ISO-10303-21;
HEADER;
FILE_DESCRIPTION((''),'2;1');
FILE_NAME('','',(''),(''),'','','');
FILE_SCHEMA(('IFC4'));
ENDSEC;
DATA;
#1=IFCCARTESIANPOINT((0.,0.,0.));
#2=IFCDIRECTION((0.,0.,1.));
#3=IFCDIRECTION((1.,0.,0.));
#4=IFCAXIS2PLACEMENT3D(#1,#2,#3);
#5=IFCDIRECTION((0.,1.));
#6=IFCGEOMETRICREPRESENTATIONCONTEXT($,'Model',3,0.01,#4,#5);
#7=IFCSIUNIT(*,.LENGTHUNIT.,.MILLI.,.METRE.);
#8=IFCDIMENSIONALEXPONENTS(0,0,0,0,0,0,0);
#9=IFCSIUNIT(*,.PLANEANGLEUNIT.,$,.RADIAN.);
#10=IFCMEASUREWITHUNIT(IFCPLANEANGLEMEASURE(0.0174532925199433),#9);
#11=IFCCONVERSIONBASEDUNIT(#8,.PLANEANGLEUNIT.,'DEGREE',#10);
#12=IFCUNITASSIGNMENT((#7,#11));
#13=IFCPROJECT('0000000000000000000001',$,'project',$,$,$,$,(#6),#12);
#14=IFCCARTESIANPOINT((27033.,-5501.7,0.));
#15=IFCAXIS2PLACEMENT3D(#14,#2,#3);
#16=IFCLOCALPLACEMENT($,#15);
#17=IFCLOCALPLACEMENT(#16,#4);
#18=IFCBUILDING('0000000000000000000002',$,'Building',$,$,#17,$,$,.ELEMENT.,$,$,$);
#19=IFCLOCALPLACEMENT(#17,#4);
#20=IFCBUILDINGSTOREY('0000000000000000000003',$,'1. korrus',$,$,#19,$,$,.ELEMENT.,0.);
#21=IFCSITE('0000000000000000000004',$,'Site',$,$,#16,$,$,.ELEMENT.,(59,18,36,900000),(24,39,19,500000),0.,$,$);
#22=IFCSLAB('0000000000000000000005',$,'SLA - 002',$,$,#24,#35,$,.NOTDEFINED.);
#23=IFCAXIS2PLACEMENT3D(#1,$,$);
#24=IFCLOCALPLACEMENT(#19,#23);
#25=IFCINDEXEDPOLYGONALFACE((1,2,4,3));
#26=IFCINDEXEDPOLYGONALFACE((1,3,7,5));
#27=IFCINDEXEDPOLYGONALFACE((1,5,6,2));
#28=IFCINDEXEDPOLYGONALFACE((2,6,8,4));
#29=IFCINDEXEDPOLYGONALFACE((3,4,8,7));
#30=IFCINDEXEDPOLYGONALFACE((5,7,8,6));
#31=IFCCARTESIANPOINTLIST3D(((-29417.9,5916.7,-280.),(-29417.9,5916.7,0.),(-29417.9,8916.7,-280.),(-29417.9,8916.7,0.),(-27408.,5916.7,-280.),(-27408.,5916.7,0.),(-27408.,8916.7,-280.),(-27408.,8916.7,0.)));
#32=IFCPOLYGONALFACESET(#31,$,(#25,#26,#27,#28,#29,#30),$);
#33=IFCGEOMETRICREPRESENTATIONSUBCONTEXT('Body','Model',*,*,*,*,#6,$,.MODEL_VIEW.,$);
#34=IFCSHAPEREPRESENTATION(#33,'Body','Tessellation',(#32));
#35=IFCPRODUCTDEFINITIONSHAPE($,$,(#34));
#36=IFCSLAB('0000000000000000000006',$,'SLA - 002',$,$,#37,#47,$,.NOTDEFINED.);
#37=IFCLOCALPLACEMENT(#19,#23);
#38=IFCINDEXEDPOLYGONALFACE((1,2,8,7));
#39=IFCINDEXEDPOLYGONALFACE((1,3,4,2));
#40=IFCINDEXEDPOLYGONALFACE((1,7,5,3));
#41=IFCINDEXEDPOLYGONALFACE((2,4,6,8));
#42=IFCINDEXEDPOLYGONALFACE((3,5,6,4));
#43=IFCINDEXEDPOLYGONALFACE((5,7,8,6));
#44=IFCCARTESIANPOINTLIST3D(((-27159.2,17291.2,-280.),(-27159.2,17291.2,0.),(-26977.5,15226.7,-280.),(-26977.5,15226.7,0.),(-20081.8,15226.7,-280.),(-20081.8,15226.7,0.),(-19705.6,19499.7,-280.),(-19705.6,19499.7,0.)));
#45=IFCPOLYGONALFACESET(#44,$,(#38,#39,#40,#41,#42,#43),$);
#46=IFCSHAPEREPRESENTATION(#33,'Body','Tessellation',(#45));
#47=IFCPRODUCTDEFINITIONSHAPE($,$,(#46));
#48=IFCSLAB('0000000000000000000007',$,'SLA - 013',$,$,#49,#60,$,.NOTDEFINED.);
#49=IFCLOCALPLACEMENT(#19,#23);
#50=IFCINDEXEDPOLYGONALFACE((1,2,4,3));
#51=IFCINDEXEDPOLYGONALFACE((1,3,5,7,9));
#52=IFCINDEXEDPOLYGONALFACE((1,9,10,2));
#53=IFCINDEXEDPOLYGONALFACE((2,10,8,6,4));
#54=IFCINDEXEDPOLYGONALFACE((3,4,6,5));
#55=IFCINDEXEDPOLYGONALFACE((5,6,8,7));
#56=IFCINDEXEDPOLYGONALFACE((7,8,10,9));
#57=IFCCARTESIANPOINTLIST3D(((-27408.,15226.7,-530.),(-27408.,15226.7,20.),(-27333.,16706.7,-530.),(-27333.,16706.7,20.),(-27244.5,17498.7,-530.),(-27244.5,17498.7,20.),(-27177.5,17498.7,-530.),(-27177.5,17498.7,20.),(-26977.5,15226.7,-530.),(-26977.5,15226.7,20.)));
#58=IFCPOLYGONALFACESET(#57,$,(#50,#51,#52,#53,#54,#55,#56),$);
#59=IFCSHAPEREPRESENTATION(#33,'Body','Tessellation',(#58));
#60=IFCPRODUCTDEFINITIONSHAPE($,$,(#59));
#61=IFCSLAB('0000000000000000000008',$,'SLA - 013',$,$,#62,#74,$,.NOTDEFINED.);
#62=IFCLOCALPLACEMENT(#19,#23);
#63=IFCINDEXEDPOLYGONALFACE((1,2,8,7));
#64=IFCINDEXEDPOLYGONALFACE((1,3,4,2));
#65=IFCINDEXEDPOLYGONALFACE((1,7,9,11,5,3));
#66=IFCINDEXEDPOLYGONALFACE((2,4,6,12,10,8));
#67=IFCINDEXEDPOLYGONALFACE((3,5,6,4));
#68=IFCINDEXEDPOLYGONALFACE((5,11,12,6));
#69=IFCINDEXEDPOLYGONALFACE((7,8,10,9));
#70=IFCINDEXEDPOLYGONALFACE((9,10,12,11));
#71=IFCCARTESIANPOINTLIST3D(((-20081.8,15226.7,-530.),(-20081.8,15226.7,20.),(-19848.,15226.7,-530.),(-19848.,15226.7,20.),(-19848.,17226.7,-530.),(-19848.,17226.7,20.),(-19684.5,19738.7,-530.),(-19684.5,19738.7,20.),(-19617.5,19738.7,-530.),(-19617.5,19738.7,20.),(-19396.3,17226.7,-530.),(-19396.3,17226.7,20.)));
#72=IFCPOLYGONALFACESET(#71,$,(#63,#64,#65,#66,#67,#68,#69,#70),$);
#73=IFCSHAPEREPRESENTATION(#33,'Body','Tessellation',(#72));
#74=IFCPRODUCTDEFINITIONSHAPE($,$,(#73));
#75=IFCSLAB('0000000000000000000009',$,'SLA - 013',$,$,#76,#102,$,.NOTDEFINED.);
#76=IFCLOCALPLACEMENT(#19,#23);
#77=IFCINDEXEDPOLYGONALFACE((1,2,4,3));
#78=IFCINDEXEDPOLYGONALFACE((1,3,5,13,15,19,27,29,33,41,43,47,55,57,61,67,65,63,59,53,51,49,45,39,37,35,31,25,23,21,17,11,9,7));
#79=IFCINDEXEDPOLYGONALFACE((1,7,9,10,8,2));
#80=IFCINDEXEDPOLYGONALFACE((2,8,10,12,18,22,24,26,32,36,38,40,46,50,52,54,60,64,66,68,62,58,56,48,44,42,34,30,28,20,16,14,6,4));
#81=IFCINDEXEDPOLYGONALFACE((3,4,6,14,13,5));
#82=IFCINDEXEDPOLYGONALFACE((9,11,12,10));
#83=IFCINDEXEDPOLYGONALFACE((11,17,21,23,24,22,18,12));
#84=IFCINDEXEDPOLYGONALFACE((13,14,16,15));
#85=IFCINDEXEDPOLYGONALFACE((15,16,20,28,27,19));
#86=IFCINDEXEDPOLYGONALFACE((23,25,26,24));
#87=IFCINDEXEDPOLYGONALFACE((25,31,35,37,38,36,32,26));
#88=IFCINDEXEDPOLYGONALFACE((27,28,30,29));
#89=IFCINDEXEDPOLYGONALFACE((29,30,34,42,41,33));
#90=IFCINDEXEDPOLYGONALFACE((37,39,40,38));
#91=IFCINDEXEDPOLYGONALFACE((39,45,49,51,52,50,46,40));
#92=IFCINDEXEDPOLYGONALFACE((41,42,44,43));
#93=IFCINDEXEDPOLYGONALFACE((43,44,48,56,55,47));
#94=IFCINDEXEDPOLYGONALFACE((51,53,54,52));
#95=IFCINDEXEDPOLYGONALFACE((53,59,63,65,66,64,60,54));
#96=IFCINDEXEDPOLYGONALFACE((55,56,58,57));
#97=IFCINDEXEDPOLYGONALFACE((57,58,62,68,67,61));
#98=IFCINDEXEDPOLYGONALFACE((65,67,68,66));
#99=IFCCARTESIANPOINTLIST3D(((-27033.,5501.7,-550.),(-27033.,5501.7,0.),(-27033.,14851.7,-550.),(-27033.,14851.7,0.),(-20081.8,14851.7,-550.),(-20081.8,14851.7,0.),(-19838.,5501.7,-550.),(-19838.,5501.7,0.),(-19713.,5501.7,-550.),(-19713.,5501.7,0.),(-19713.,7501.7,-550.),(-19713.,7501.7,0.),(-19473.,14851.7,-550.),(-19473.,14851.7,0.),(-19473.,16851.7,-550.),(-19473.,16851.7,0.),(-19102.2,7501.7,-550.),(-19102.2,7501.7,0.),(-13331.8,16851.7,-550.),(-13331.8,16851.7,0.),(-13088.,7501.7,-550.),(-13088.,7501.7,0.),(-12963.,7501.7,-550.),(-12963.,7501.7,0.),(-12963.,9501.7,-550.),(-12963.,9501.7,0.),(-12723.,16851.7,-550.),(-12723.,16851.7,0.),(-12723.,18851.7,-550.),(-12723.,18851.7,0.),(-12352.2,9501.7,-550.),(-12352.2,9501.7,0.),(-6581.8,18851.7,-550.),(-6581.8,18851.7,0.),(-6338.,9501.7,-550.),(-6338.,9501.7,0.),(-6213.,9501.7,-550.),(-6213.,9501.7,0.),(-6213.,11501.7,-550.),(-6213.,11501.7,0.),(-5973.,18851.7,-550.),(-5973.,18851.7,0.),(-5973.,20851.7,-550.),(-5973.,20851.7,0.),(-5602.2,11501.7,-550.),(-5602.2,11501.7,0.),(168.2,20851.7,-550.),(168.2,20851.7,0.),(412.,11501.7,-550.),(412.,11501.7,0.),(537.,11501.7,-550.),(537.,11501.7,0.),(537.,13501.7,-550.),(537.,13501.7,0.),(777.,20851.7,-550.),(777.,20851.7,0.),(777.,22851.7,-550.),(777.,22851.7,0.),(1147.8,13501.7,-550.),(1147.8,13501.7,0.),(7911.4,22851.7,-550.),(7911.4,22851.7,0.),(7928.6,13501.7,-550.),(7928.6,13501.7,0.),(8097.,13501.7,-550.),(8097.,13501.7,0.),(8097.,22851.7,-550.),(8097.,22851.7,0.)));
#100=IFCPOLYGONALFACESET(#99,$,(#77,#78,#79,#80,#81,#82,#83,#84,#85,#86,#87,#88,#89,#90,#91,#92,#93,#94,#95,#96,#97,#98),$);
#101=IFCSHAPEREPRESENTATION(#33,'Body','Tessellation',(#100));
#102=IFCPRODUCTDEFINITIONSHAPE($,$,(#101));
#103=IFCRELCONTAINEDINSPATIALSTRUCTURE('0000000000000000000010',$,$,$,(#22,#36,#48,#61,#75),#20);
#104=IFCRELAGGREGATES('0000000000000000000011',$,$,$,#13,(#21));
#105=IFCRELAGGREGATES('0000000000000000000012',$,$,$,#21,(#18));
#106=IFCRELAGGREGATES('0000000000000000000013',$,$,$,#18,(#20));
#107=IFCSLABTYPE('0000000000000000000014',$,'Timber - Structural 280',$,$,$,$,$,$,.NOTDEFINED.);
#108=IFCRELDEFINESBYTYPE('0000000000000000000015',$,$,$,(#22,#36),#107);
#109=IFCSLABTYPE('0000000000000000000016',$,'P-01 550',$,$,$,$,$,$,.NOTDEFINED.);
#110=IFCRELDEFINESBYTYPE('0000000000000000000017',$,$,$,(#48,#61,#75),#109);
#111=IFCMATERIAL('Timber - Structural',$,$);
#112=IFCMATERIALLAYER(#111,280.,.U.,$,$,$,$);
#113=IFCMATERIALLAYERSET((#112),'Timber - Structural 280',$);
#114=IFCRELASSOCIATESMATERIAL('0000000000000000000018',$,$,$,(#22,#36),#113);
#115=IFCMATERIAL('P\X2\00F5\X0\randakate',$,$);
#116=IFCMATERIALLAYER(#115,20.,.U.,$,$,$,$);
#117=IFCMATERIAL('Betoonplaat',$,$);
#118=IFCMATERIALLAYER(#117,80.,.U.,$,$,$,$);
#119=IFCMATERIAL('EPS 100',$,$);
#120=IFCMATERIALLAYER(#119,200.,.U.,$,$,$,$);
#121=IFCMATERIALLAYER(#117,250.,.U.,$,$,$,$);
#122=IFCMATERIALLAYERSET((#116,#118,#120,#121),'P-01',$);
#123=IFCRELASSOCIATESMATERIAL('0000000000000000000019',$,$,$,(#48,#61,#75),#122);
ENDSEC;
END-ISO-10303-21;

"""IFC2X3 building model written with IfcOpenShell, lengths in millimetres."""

from ifc_helpers import new_model, entity, si_unit, converted_unit, direction, frame, origin_with_axes, place, context, subcontext, project, spatial, polyline, outline, extrude, material, layer, layer_set, layer_usage, type_object, element, save


model = new_model("IFC2X3")

# Units and contexts
model_context = context("Model", 3, precision=0.01, world=origin_with_axes(), true_north=direction((0.0, 1.0)))
body_context = subcontext(model_context, "Body", "Model", "MODEL_VIEW")
ifc_project = project(units=[si_unit("LENGTHUNIT", "METRE", prefix="MILLI"), converted_unit("PLANEANGLEUNIT", "DEGREE", entity("IfcPlaneAngleMeasure", 0.0174532925199433), si_unit("PLANEANGLEUNIT", "RADIAN"), dimensions=[0, 0, 0, 0, 0, 0, 0])], contexts=[model_context])

# Site, building, storey
site_placement = place(None, frame((27033.0, -5501.7, 0.0), z_axis=(0.0, 0.0, 1.0), x_axis=(1.0, 0.0, 0.0)))
site = spatial("IfcSite", under=ifc_project, at=site_placement, Name="Site", CompositionType="ELEMENT", RefLatitude=(59, 18, 36, 900000), RefLongitude=(24, 39, 19, 500000), RefElevation=0.0)
building_placement = place(site_placement, origin_with_axes())
building = spatial("IfcBuilding", under=site, at=building_placement, Name="Building", CompositionType="ELEMENT")
storey_placement = place(building_placement, origin_with_axes())
storey = spatial("IfcBuildingStorey", under=building, at=storey_placement, Name="1. korrus", CompositionType="ELEMENT", Elevation=0.0)

# Slabs
ifc_material_1 = material(Name="Timber - Structural")
ifc_layer_1 = layer(ifc_material_1, 280.0, ventilated="UNKNOWN")
ifc_layer_set_1 = layer_set([ifc_layer_1], Name="Timber - Structural 280")
ifc_layer_usage_1 = layer_usage(ifc_layer_set_1, "AXIS3", "NEGATIVE", 280.0)
slab_type_1 = type_object("IfcSlabType", Name="Timber - Structural 280", PredefinedType="NOTDEFINED")
slab_1_placement = place(storey_placement, frame((-29417.9, 8916.7, 0.0), z_axis=(0.0, 0.0, 1.0), x_axis=(1.0, 0.0, 0.0)))
element("IfcSlab", 1, at=slab_1_placement, inside=storey, type_object=slab_type_1, material=ifc_layer_usage_1, Name="SLA - 002", PredefinedType="NOTDEFINED", context=body_context, shape_type="SweptSolid", body=[
    extrude(outline(polyline([(0.0, 0.0), (0.0, -3000.0), (2009.9, -3000.0), (2009.9, 0.0), (0.0, 0.0)])), frame((0.0, 0.0, -280.0), z_axis=(0.0, 0.0, 1.0), x_axis=(1.0, 0.0, 0.0)), (0.0, 0.0, 1.0), 280.0),
])
ifc_layer_usage_2 = layer_usage(ifc_layer_set_1, "AXIS3", "NEGATIVE", 280.0)
slab_2_placement = place(storey_placement, frame((-27159.2, 17291.2, 0.0), z_axis=(0.0, 0.0, 1.0), x_axis=(1.0, 0.0, 0.0)))
element("IfcSlab", 2, at=slab_2_placement, inside=storey, type_object=slab_type_1, material=ifc_layer_usage_2, Name="SLA - 002", PredefinedType="NOTDEFINED", context=body_context, shape_type="SweptSolid", body=[
    extrude(outline(polyline([(0.0, 0.0), (181.8, -2064.5), (7077.4, -2064.5), (7453.7, 2208.5), (0.0, 0.0)])), frame((0.0, 0.0, -280.0), z_axis=(0.0, 0.0, 1.0), x_axis=(1.0, 0.0, 0.0)), (0.0, 0.0, 1.0), 280.0),
])
ifc_material_2 = material(Name="Põrandakate")
ifc_layer_2 = layer(ifc_material_2, 20.0, ventilated="UNKNOWN")
ifc_material_3 = material(Name="Betoonplaat")
ifc_layer_3 = layer(ifc_material_3, 80.0, ventilated="UNKNOWN")
ifc_material_4 = material(Name="EPS 100")
ifc_layer_4 = layer(ifc_material_4, 200.0, ventilated="UNKNOWN")
ifc_layer_5 = layer(ifc_material_3, 250.0, ventilated="UNKNOWN")
ifc_layer_set_2 = layer_set([ifc_layer_2, ifc_layer_3, ifc_layer_4, ifc_layer_5], Name="P-01")
ifc_layer_usage_3 = layer_usage(ifc_layer_set_2, "AXIS3", "NEGATIVE", 550.0)
slab_type_2 = type_object("IfcSlabType", Name="P-01 550", PredefinedType="NOTDEFINED")
slab_3_placement = place(storey_placement, frame((-27408.0, 15226.7, 0.0), z_axis=(0.0, 0.0, 1.0), x_axis=(1.0, 0.0, 0.0)))
element("IfcSlab", 3, at=slab_3_placement, inside=storey, type_object=slab_type_2, material=ifc_layer_usage_3, Name="SLA - 013", PredefinedType="NOTDEFINED", context=body_context, shape_type="SweptSolid", body=[
    extrude(outline(polyline([(0.0, 0.0), (430.5, 0.0), (230.5, 2272.0), (163.5, 2272.0), (75.0, 1480.0), (0.0, 0.0)])), frame((0.0, 0.0, -530.0), z_axis=(0.0, 0.0, 1.0), x_axis=(1.0, 0.0, 0.0)), (0.0, 0.0, 1.0), 550.0),
])
ifc_layer_usage_4 = layer_usage(ifc_layer_set_2, "AXIS3", "NEGATIVE", 550.0)
slab_4_placement = place(storey_placement, frame((-20081.8, 15226.7, 0.0), z_axis=(0.0, 0.0, 1.0), x_axis=(1.0, 0.0, 0.0)))
element("IfcSlab", 4, at=slab_4_placement, inside=storey, type_object=slab_type_2, material=ifc_layer_usage_4, Name="SLA - 013", PredefinedType="NOTDEFINED", context=body_context, shape_type="SweptSolid", body=[
    extrude(outline(polyline([(0.0, 0.0), (233.8, 0.0), (233.8, 2000.0), (685.5, 2000.0), (464.3, 4512.0), (397.3, 4512.0), (0.0, 0.0)])), frame((0.0, 0.0, -530.0), z_axis=(0.0, 0.0, 1.0), x_axis=(1.0, 0.0, 0.0)), (0.0, 0.0, 1.0), 550.0),
])
ifc_layer_usage_5 = layer_usage(ifc_layer_set_2, "AXIS3", "NEGATIVE", 550.0)
slab_5_placement = place(storey_placement, frame((-27033.0, 14851.7, 0.0), z_axis=(0.0, 0.0, 1.0), x_axis=(1.0, 0.0, 0.0)))
element("IfcSlab", 5, at=slab_5_placement, inside=storey, type_object=slab_type_2, material=ifc_layer_usage_5, Name="SLA - 013", PredefinedType="NOTDEFINED", context=body_context, shape_type="SweptSolid", body=[
    extrude(outline(polyline([(0.0, 0.0), (0.0, -9350.0), (7195.0, -9350.0), (7320.0, -9350.0), (7320.0, -7350.0), (7930.8, -7350.0), (13945.0, -7350.0), (14070.0, -7350.0), (14070.0, -5350.0), (14680.8, -5350.0), (20695.0, -5350.0), (20820.0, -5350.0), (20820.0, -3350.0), (21430.8, -3350.0), (27444.9, -3350.0), (27569.9, -3350.0), (27570.0, -1350.0), (28180.7, -1350.0), (34961.5, -1350.0), (35130.0, -1350.0), (35130.0, 8000.0), (34944.3, 8000.0), (27810.0, 8000.0), (27810.0, 6000.0), (27201.2, 6000.0), (21060.0, 6000.0), (21060.0, 4000.0), (20451.2, 4000.0), (14310.0, 4000.0), (14310.0, 2000.0), (13701.2, 2000.0), (7560.0, 2000.0), (7560.0, 0.0), (6951.2, 0.0), (0.0, 0.0)])), frame((0.0, 0.0, -550.0), z_axis=(0.0, 0.0, 1.0), x_axis=(1.0, 0.0, 0.0)), (0.0, 0.0, 1.0), 550.0),
])

save(model, "model.ifc")
